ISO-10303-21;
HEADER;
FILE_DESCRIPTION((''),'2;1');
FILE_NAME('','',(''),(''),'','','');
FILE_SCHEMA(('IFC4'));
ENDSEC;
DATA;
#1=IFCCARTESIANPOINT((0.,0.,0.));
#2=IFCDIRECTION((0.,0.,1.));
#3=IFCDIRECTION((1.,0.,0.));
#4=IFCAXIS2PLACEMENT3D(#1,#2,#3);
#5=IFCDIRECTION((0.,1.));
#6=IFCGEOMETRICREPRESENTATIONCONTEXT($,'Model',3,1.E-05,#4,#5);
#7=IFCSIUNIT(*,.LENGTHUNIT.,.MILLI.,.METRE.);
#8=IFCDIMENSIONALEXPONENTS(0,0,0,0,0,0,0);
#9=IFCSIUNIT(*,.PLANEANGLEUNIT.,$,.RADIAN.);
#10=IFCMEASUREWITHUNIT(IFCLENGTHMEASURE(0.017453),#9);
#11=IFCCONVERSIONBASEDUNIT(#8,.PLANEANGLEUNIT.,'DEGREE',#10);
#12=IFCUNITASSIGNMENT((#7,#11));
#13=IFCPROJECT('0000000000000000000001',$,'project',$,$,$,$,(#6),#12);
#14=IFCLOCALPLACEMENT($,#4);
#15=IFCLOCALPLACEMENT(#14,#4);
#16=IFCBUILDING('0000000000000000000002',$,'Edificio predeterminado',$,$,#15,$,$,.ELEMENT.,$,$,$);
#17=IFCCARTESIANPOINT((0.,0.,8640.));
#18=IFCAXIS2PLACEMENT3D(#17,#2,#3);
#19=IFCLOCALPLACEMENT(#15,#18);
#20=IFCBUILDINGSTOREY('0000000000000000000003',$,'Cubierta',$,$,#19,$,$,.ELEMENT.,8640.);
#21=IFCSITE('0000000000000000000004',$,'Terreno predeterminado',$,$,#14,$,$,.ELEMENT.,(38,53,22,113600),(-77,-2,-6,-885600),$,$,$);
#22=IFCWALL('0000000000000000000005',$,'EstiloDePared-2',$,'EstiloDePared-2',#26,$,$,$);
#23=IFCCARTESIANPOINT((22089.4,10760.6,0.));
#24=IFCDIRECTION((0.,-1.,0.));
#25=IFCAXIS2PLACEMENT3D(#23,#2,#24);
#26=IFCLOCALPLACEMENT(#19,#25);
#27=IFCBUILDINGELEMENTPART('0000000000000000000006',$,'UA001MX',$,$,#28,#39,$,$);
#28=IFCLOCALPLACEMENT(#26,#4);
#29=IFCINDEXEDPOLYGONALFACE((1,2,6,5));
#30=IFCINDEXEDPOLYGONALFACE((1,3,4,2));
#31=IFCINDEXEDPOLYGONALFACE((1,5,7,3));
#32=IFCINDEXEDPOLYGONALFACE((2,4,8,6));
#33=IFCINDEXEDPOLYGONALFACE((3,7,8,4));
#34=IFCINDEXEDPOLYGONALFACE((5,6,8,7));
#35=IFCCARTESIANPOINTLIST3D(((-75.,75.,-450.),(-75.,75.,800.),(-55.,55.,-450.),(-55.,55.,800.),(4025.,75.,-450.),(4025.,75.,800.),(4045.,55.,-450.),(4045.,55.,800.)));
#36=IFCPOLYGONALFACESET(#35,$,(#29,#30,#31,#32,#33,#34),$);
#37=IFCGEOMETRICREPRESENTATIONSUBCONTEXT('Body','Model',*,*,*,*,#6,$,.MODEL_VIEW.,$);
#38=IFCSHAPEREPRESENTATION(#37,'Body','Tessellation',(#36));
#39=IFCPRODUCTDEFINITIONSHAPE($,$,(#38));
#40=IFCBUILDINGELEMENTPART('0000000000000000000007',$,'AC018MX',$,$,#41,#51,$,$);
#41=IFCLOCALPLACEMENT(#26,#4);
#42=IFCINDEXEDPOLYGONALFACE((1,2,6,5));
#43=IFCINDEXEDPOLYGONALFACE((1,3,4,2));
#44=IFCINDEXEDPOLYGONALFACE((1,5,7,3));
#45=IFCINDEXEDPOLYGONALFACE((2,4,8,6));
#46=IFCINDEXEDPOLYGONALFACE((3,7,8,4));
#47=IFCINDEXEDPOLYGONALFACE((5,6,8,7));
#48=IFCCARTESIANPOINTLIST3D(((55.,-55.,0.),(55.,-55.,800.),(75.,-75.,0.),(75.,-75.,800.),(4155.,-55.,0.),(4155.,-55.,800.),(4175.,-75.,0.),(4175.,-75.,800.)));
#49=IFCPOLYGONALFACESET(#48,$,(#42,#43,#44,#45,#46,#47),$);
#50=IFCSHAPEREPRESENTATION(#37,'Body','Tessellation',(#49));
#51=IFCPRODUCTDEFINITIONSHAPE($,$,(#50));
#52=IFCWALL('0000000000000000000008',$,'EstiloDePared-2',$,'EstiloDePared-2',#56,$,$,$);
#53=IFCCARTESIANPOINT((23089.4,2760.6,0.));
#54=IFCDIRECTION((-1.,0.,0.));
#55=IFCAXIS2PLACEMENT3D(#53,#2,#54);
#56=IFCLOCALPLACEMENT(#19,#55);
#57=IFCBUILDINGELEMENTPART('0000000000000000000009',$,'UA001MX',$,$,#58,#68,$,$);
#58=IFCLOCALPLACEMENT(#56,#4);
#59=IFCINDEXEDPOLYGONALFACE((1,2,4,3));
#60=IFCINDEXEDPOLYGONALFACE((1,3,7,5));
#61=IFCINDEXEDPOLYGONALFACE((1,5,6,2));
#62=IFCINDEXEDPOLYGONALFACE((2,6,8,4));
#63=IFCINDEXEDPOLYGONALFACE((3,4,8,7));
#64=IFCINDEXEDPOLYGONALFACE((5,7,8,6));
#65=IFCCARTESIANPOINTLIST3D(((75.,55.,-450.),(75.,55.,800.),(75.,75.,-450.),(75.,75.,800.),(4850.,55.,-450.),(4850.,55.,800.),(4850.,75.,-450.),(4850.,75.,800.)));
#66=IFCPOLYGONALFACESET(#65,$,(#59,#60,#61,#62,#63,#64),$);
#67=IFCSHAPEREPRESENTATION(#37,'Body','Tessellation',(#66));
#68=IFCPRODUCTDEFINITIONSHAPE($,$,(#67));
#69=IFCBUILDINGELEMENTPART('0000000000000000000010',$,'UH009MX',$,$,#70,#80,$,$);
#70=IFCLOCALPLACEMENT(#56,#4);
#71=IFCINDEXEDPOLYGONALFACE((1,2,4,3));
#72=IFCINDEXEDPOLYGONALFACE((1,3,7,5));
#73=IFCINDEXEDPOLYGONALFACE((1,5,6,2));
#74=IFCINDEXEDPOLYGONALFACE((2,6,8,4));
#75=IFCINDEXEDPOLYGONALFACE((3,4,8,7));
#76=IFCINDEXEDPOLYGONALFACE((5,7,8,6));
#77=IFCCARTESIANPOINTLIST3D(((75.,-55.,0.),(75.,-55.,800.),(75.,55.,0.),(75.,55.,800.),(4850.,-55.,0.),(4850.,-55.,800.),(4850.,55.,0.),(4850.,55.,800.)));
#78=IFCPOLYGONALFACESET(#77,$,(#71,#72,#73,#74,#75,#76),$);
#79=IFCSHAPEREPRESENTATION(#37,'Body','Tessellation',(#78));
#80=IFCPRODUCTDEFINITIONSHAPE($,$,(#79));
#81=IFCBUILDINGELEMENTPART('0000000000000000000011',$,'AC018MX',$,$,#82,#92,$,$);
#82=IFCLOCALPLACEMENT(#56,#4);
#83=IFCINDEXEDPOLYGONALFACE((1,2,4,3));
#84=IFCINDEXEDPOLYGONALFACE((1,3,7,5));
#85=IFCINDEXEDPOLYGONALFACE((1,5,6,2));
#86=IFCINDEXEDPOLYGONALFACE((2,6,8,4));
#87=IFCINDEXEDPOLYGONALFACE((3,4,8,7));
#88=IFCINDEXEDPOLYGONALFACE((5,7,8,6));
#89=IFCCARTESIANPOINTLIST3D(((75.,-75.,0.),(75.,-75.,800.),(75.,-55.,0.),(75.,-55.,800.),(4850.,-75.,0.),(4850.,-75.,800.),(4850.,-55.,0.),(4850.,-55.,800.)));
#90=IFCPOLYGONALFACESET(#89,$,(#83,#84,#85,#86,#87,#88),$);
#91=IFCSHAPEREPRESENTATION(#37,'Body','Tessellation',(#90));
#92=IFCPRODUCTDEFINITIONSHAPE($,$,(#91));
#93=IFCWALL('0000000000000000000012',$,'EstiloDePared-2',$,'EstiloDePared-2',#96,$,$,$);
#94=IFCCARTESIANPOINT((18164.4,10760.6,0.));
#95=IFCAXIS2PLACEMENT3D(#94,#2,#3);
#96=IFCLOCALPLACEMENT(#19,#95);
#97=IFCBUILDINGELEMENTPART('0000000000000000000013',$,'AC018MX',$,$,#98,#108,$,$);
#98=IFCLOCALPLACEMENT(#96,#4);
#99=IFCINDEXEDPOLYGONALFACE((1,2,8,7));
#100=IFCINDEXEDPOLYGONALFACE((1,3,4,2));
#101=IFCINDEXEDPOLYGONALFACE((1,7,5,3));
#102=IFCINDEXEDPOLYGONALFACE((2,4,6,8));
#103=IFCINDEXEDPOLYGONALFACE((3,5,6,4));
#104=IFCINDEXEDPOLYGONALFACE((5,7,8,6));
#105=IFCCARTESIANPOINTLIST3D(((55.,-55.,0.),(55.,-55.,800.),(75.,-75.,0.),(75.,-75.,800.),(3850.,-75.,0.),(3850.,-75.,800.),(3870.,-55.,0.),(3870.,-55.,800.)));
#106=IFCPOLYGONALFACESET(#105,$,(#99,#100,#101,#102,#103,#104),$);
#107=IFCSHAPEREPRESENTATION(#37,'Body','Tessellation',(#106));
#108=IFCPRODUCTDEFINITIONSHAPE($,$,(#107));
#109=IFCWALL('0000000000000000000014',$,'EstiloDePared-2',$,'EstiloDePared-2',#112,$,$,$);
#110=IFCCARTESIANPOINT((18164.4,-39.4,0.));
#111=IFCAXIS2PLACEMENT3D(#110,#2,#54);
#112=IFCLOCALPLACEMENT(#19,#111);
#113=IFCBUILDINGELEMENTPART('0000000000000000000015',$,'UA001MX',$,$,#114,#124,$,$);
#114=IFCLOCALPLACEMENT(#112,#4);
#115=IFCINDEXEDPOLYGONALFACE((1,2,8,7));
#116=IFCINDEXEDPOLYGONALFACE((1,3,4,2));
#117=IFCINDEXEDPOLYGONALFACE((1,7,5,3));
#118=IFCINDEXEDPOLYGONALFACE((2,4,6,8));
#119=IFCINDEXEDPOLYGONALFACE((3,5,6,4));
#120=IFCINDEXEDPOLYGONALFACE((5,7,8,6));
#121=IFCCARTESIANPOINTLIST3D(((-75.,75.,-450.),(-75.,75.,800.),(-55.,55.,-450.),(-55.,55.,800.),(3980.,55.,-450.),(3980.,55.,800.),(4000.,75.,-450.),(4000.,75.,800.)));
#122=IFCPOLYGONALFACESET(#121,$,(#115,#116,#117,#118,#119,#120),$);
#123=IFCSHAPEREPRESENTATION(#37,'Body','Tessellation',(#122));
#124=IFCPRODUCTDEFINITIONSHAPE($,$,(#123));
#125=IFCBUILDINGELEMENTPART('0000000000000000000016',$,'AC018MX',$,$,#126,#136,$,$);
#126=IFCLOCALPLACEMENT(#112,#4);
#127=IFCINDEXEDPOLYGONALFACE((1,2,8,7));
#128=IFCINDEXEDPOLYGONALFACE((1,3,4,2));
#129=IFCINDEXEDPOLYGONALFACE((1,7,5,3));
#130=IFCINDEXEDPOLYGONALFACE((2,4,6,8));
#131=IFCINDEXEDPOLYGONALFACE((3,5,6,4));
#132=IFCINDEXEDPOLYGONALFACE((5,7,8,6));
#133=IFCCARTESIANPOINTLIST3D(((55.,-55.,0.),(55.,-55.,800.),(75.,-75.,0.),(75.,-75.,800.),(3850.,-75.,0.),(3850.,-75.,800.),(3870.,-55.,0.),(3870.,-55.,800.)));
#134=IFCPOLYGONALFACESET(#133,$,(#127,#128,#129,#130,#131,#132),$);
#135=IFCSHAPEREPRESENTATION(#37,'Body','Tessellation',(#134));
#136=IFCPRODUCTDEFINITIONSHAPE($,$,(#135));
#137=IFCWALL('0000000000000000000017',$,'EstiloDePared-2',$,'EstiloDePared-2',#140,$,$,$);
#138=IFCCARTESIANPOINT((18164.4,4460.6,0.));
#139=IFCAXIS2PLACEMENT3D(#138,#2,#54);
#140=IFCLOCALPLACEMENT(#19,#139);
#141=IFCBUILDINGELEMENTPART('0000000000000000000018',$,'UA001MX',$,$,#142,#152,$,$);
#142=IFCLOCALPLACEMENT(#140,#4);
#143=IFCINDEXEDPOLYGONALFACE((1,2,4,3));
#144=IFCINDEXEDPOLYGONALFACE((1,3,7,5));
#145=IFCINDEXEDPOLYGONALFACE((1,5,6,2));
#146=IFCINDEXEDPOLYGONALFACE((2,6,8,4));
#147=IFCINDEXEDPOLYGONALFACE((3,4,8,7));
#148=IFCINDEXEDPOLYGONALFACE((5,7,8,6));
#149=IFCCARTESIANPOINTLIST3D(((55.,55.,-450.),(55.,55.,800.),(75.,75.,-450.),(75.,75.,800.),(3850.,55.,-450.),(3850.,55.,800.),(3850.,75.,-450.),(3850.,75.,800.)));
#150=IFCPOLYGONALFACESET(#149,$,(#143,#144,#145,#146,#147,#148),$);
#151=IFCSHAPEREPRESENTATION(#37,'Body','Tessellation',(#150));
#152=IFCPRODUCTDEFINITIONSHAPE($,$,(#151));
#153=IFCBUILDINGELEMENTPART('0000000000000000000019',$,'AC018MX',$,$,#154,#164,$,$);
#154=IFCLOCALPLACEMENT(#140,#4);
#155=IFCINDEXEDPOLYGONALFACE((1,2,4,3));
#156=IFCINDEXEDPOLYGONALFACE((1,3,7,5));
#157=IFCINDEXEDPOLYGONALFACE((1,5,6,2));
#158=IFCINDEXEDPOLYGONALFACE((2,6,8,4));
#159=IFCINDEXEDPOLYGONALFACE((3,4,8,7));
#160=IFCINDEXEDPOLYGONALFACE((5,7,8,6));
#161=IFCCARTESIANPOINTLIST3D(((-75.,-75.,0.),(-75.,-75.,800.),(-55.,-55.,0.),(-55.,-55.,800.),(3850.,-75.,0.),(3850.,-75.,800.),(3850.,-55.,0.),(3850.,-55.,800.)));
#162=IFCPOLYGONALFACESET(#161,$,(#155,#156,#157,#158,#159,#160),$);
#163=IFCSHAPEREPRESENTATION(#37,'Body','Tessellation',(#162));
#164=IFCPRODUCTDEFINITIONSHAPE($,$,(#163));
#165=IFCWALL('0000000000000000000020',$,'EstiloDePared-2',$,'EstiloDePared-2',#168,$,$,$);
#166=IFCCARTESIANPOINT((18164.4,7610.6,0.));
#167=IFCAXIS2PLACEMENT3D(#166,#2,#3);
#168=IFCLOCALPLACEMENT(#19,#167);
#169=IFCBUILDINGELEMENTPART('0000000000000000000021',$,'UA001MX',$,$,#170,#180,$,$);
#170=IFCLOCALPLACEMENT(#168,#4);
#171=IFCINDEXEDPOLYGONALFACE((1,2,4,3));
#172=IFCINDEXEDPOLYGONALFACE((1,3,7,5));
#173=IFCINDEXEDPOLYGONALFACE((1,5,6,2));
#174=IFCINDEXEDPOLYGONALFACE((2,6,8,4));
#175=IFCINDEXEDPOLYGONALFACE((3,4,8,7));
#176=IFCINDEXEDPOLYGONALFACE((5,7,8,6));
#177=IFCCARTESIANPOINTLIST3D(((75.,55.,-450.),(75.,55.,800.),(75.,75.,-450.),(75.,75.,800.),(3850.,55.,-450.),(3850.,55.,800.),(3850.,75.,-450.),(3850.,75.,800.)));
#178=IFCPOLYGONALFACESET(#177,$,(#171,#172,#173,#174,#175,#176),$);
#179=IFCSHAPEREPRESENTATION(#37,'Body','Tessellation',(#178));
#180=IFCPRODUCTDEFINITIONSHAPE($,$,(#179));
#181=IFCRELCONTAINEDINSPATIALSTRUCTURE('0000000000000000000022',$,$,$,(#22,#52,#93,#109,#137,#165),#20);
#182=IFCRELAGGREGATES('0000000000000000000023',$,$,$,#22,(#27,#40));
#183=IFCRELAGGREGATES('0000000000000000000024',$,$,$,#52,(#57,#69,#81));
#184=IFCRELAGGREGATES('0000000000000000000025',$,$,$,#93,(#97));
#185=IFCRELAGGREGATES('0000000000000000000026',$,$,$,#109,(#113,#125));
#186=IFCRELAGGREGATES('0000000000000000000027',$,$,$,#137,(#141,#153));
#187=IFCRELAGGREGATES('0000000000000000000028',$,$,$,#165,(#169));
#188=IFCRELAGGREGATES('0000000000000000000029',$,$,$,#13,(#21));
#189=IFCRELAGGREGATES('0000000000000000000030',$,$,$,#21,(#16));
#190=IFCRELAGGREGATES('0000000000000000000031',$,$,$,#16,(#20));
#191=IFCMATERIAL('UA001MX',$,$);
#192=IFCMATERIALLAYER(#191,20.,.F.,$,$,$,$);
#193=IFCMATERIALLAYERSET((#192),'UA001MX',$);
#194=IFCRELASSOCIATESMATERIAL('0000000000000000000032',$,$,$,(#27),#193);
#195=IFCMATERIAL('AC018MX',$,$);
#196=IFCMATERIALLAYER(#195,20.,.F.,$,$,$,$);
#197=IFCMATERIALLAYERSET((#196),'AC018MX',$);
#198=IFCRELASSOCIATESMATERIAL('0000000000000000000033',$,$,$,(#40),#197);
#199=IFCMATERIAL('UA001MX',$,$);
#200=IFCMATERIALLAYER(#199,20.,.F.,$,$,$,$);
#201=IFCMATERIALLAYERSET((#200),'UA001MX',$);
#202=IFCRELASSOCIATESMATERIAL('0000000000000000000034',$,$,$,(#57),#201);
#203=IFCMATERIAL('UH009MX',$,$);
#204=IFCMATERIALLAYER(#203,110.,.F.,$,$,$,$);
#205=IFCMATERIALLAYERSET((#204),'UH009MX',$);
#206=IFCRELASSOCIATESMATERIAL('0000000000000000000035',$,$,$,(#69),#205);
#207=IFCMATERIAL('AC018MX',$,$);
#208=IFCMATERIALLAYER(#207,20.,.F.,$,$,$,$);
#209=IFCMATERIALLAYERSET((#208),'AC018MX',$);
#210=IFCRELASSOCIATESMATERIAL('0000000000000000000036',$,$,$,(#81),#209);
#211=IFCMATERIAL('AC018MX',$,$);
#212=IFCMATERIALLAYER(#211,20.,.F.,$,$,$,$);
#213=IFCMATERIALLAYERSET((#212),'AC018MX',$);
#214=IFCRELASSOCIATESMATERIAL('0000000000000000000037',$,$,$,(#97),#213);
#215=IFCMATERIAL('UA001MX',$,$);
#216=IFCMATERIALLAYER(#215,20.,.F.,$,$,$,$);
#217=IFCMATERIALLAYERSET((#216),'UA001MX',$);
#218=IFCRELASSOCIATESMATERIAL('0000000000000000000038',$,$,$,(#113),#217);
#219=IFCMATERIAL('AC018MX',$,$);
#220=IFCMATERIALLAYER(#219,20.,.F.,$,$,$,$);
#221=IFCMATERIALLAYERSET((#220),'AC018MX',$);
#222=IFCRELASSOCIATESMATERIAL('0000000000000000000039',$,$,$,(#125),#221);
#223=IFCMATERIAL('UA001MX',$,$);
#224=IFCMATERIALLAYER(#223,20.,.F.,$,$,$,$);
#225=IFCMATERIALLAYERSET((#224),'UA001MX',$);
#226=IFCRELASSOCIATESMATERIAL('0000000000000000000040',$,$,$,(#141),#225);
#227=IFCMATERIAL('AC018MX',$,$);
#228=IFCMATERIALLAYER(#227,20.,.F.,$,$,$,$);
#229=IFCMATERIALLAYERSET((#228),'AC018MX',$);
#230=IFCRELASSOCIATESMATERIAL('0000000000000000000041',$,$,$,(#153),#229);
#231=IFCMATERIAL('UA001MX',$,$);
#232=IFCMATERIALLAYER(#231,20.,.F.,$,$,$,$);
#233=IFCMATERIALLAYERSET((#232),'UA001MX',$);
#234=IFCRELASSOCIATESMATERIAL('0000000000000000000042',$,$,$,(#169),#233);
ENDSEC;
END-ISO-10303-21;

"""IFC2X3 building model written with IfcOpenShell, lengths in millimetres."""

from ifc_helpers import new_model, entity, si_unit, converted_unit, direction, frame, origin_with_axes, place, context, subcontext, project, spatial, polyline, outline, extrude, material, layer, layer_set, layer_usage, element, aggregate, save


model = new_model("IFC2X3")

# Units and contexts
model_context = context("Model", 3, precision=1e-05, world=origin_with_axes(), true_north=direction((0.0, 1.0)))
body_context = subcontext(model_context, "Body", "Model", "MODEL_VIEW")
ifc_project = project(units=[si_unit("LENGTHUNIT", "METRE", prefix="MILLI"), converted_unit("PLANEANGLEUNIT", "DEGREE", entity("IfcLengthMeasure", 0.017453), si_unit("PLANEANGLEUNIT", "RADIAN"), dimensions=[0, 0, 0, 0, 0, 0, 0])], contexts=[model_context])

# Site, building, storey
site_placement = place(None, origin_with_axes())
site = spatial("IfcSite", under=ifc_project, at=site_placement, Name="Terreno predeterminado", CompositionType="ELEMENT", RefLatitude=(38, 53, 22, 113600), RefLongitude=(-77, -2, -6, -885600))
building_placement = place(site_placement, origin_with_axes())
building = spatial("IfcBuilding", under=site, at=building_placement, Name="Edificio predeterminado", CompositionType="ELEMENT")
storey_placement = place(building_placement, frame((0.0, 0.0, 8640.0), z_axis=(0.0, 0.0, 1.0), x_axis=(1.0, 0.0, 0.0)))
storey = spatial("IfcBuildingStorey", under=building, at=storey_placement, Name="Cubierta", CompositionType="ELEMENT", Elevation=8640.0)

# Walls, building element parts
wall_1_placement = place(storey_placement, frame((22089.4, 10760.6, 0.0), z_axis=(0.0, 0.0, 1.0), x_axis=(0.0, -1.0, 0.0)))
wall_1 = element("IfcWall", 1, at=wall_1_placement, inside=storey, Name="EstiloDePared-2", ObjectType="EstiloDePared-2")
ifc_material_1 = material(Name="UA001MX")
ifc_layer_1 = layer(ifc_material_1, 20.0, ventilated=False)
ifc_layer_set_1 = layer_set([ifc_layer_1], Name="UA001MX")
ifc_layer_usage_1 = layer_usage(ifc_layer_set_1, "AXIS2", "NEGATIVE", -75.0)
building_element_part_1_placement = place(wall_1_placement, origin_with_axes())
building_element_part_1 = element("IfcBuildingElementPart", 2, at=building_element_part_1_placement, material=ifc_layer_usage_1, Name="UA001MX", context=body_context, shape_type="SweptSolid", body=[
    extrude(outline(polyline([(4025.0, 75.0), (4045.0, 55.0), (-55.0, 55.0), (-75.0, 75.0), (4025.0, 75.0)])), frame((0.0, 0.0, -450.0), z_axis=(0.0, 0.0, 1.0), x_axis=(1.0, 0.0, 0.0)), (0.0, 0.0, 1.0), 1250.0),
])
ifc_material_2 = material(Name="AC018MX")
ifc_layer_2 = layer(ifc_material_2, 20.0, ventilated=False)
ifc_layer_set_2 = layer_set([ifc_layer_2], Name="AC018MX")
ifc_layer_usage_2 = layer_usage(ifc_layer_set_2, "AXIS2", "NEGATIVE", 55.0)
building_element_part_2_placement = place(wall_1_placement, origin_with_axes())
building_element_part_2 = element("IfcBuildingElementPart", 3, at=building_element_part_2_placement, material=ifc_layer_usage_2, Name="AC018MX", context=body_context, shape_type="SweptSolid", body=[
    extrude(outline(polyline([(4155.0, -55.0), (4175.0, -75.0), (75.0, -75.0), (55.0, -55.0), (4155.0, -55.0)])), origin_with_axes(), (0.0, 0.0, 1.0), 800.0),
])
aggregate(wall_1, [building_element_part_1, building_element_part_2])
wall_2_placement = place(storey_placement, frame((23089.4, 2760.6, 0.0), z_axis=(0.0, 0.0, 1.0), x_axis=(-1.0, 0.0, 0.0)))
wall_2 = element("IfcWall", 4, at=wall_2_placement, inside=storey, Name="EstiloDePared-2", ObjectType="EstiloDePared-2")
ifc_material_3 = material(Name="UA001MX")
ifc_layer_3 = layer(ifc_material_3, 20.0, ventilated=False)
ifc_layer_set_3 = layer_set([ifc_layer_3], Name="UA001MX")
ifc_layer_usage_3 = layer_usage(ifc_layer_set_3, "AXIS2", "NEGATIVE", -75.0)
building_element_part_3_placement = place(wall_2_placement, origin_with_axes())
building_element_part_3 = element("IfcBuildingElementPart", 5, at=building_element_part_3_placement, material=ifc_layer_usage_3, Name="UA001MX", context=body_context, shape_type="SweptSolid", body=[
    extrude(outline(polyline([(4850.0, 75.0), (4850.0, 55.0), (75.0, 55.0), (75.0, 75.0), (4850.0, 75.0)])), frame((0.0, 0.0, -450.0), z_axis=(0.0, 0.0, 1.0), x_axis=(1.0, 0.0, 0.0)), (0.0, 0.0, 1.0), 1250.0),
])
ifc_material_4 = material(Name="UH009MX")
ifc_layer_4 = layer(ifc_material_4, 110.0, ventilated=False)
ifc_layer_set_4 = layer_set([ifc_layer_4], Name="UH009MX")
ifc_layer_usage_4 = layer_usage(ifc_layer_set_4, "AXIS2", "NEGATIVE", -55.0)
building_element_part_4_placement = place(wall_2_placement, origin_with_axes())
building_element_part_4 = element("IfcBuildingElementPart", 6, at=building_element_part_4_placement, material=ifc_layer_usage_4, Name="UH009MX", context=body_context, shape_type="SweptSolid", body=[
    extrude(outline(polyline([(4850.0, 55.0), (4850.0, -55.0), (75.0, -55.0), (75.0, 55.0), (4850.0, 55.0)])), origin_with_axes(), (0.0, 0.0, 1.0), 800.0),
])
ifc_material_5 = material(Name="AC018MX")
ifc_layer_5 = layer(ifc_material_5, 20.0, ventilated=False)
ifc_layer_set_5 = layer_set([ifc_layer_5], Name="AC018MX")
ifc_layer_usage_5 = layer_usage(ifc_layer_set_5, "AXIS2", "NEGATIVE", 55.0)
building_element_part_5_placement = place(wall_2_placement, origin_with_axes())
building_element_part_5 = element("IfcBuildingElementPart", 7, at=building_element_part_5_placement, material=ifc_layer_usage_5, Name="AC018MX", context=body_context, shape_type="SweptSolid", body=[
    extrude(outline(polyline([(4850.0, -55.0), (4850.0, -75.0), (75.0, -75.0), (75.0, -55.0), (4850.0, -55.0)])), origin_with_axes(), (0.0, 0.0, 1.0), 800.0),
])
aggregate(wall_2, [building_element_part_3, building_element_part_4, building_element_part_5])

# Wall, building element part
wall_3_placement = place(storey_placement, frame((18164.4, 10760.6, 0.0), z_axis=(0.0, 0.0, 1.0), x_axis=(1.0, 0.0, 0.0)))
wall_3 = element("IfcWall", 8, at=wall_3_placement, inside=storey, Name="EstiloDePared-2", ObjectType="EstiloDePared-2")
ifc_material_6 = material(Name="AC018MX")
ifc_layer_6 = layer(ifc_material_6, 20.0, ventilated=False)
ifc_layer_set_6 = layer_set([ifc_layer_6], Name="AC018MX")
ifc_layer_usage_6 = layer_usage(ifc_layer_set_6, "AXIS2", "NEGATIVE", 55.0)
building_element_part_6_placement = place(wall_3_placement, origin_with_axes())
building_element_part_6 = element("IfcBuildingElementPart", 9, at=building_element_part_6_placement, material=ifc_layer_usage_6, Name="AC018MX", context=body_context, shape_type="SweptSolid", body=[
    extrude(outline(polyline([(3870.0, -55.0), (3850.0, -75.0), (75.0, -75.0), (55.0, -55.0), (3870.0, -55.0)])), origin_with_axes(), (0.0, 0.0, 1.0), 800.0),
])
aggregate(wall_3, [building_element_part_6])

# Walls, building element parts
wall_4_placement = place(storey_placement, frame((18164.4, -39.4, 0.0), z_axis=(0.0, 0.0, 1.0), x_axis=(-1.0, 0.0, 0.0)))
wall_4 = element("IfcWall", 10, at=wall_4_placement, inside=storey, Name="EstiloDePared-2", ObjectType="EstiloDePared-2")
ifc_material_7 = material(Name="UA001MX")
ifc_layer_7 = layer(ifc_material_7, 20.0, ventilated=False)
ifc_layer_set_7 = layer_set([ifc_layer_7], Name="UA001MX")
ifc_layer_usage_7 = layer_usage(ifc_layer_set_7, "AXIS2", "NEGATIVE", -75.0)
building_element_part_7_placement = place(wall_4_placement, origin_with_axes())
building_element_part_7 = element("IfcBuildingElementPart", 11, at=building_element_part_7_placement, material=ifc_layer_usage_7, Name="UA001MX", context=body_context, shape_type="SweptSolid", body=[
    extrude(outline(polyline([(4000.0, 75.0), (3980.0, 55.0), (-55.0, 55.0), (-75.0, 75.0), (4000.0, 75.0)])), frame((0.0, 0.0, -450.0), z_axis=(0.0, 0.0, 1.0), x_axis=(1.0, 0.0, 0.0)), (0.0, 0.0, 1.0), 1250.0),
])
ifc_material_8 = material(Name="AC018MX")
ifc_layer_8 = layer(ifc_material_8, 20.0, ventilated=False)
ifc_layer_set_8 = layer_set([ifc_layer_8], Name="AC018MX")
ifc_layer_usage_8 = layer_usage(ifc_layer_set_8, "AXIS2", "NEGATIVE", 55.0)
building_element_part_8_placement = place(wall_4_placement, origin_with_axes())
building_element_part_8 = element("IfcBuildingElementPart", 12, at=building_element_part_8_placement, material=ifc_layer_usage_8, Name="AC018MX", context=body_context, shape_type="SweptSolid", body=[
    extrude(outline(polyline([(3870.0, -55.0), (3850.0, -75.0), (75.0, -75.0), (55.0, -55.0), (3870.0, -55.0)])), origin_with_axes(), (0.0, 0.0, 1.0), 800.0),
])
aggregate(wall_4, [building_element_part_7, building_element_part_8])
wall_5_placement = place(storey_placement, frame((18164.4, 4460.6, 0.0), z_axis=(0.0, 0.0, 1.0), x_axis=(-1.0, 0.0, 0.0)))
wall_5 = element("IfcWall", 13, at=wall_5_placement, inside=storey, Name="EstiloDePared-2", ObjectType="EstiloDePared-2")
ifc_material_9 = material(Name="UA001MX")
ifc_layer_9 = layer(ifc_material_9, 20.0, ventilated=False)
ifc_layer_set_9 = layer_set([ifc_layer_9], Name="UA001MX")
ifc_layer_usage_9 = layer_usage(ifc_layer_set_9, "AXIS2", "NEGATIVE", -75.0)
building_element_part_9_placement = place(wall_5_placement, origin_with_axes())
building_element_part_9 = element("IfcBuildingElementPart", 14, at=building_element_part_9_placement, material=ifc_layer_usage_9, Name="UA001MX", context=body_context, shape_type="SweptSolid", body=[
    extrude(outline(polyline([(3850.0, 75.0), (3850.0, 55.0), (55.0, 55.0), (75.0, 75.0), (3850.0, 75.0)])), frame((0.0, 0.0, -450.0), z_axis=(0.0, 0.0, 1.0), x_axis=(1.0, 0.0, 0.0)), (0.0, 0.0, 1.0), 1250.0),
])
ifc_material_10 = material(Name="AC018MX")
ifc_layer_10 = layer(ifc_material_10, 20.0, ventilated=False)
ifc_layer_set_10 = layer_set([ifc_layer_10], Name="AC018MX")
ifc_layer_usage_10 = layer_usage(ifc_layer_set_10, "AXIS2", "NEGATIVE", 55.0)
building_element_part_10_placement = place(wall_5_placement, origin_with_axes())
building_element_part_10 = element("IfcBuildingElementPart", 15, at=building_element_part_10_placement, material=ifc_layer_usage_10, Name="AC018MX", context=body_context, shape_type="SweptSolid", body=[
    extrude(outline(polyline([(3850.0, -55.0), (3850.0, -75.0), (-75.0, -75.0), (-55.0, -55.0), (3850.0, -55.0)])), origin_with_axes(), (0.0, 0.0, 1.0), 800.0),
])
aggregate(wall_5, [building_element_part_9, building_element_part_10])
wall_6_placement = place(storey_placement, frame((18164.4, 7610.6, 0.0), z_axis=(0.0, 0.0, 1.0), x_axis=(1.0, 0.0, 0.0)))
wall_6 = element("IfcWall", 16, at=wall_6_placement, inside=storey, Name="EstiloDePared-2", ObjectType="EstiloDePared-2")
ifc_material_11 = material(Name="UA001MX")
ifc_layer_11 = layer(ifc_material_11, 20.0, ventilated=False)
ifc_layer_set_11 = layer_set([ifc_layer_11], Name="UA001MX")
ifc_layer_usage_11 = layer_usage(ifc_layer_set_11, "AXIS2", "NEGATIVE", -75.0)
building_element_part_11_placement = place(wall_6_placement, origin_with_axes())
building_element_part_11 = element("IfcBuildingElementPart", 17, at=building_element_part_11_placement, material=ifc_layer_usage_11, Name="UA001MX", context=body_context, shape_type="SweptSolid", body=[
    extrude(outline(polyline([(3850.0, 75.0), (3850.0, 55.0), (75.0, 55.0), (75.0, 75.0), (3850.0, 75.0)])), frame((0.0, 0.0, -450.0), z_axis=(0.0, 0.0, 1.0), x_axis=(1.0, 0.0, 0.0)), (0.0, 0.0, 1.0), 1250.0),
])
aggregate(wall_6, [building_element_part_11])

save(model, "model.ifc")
